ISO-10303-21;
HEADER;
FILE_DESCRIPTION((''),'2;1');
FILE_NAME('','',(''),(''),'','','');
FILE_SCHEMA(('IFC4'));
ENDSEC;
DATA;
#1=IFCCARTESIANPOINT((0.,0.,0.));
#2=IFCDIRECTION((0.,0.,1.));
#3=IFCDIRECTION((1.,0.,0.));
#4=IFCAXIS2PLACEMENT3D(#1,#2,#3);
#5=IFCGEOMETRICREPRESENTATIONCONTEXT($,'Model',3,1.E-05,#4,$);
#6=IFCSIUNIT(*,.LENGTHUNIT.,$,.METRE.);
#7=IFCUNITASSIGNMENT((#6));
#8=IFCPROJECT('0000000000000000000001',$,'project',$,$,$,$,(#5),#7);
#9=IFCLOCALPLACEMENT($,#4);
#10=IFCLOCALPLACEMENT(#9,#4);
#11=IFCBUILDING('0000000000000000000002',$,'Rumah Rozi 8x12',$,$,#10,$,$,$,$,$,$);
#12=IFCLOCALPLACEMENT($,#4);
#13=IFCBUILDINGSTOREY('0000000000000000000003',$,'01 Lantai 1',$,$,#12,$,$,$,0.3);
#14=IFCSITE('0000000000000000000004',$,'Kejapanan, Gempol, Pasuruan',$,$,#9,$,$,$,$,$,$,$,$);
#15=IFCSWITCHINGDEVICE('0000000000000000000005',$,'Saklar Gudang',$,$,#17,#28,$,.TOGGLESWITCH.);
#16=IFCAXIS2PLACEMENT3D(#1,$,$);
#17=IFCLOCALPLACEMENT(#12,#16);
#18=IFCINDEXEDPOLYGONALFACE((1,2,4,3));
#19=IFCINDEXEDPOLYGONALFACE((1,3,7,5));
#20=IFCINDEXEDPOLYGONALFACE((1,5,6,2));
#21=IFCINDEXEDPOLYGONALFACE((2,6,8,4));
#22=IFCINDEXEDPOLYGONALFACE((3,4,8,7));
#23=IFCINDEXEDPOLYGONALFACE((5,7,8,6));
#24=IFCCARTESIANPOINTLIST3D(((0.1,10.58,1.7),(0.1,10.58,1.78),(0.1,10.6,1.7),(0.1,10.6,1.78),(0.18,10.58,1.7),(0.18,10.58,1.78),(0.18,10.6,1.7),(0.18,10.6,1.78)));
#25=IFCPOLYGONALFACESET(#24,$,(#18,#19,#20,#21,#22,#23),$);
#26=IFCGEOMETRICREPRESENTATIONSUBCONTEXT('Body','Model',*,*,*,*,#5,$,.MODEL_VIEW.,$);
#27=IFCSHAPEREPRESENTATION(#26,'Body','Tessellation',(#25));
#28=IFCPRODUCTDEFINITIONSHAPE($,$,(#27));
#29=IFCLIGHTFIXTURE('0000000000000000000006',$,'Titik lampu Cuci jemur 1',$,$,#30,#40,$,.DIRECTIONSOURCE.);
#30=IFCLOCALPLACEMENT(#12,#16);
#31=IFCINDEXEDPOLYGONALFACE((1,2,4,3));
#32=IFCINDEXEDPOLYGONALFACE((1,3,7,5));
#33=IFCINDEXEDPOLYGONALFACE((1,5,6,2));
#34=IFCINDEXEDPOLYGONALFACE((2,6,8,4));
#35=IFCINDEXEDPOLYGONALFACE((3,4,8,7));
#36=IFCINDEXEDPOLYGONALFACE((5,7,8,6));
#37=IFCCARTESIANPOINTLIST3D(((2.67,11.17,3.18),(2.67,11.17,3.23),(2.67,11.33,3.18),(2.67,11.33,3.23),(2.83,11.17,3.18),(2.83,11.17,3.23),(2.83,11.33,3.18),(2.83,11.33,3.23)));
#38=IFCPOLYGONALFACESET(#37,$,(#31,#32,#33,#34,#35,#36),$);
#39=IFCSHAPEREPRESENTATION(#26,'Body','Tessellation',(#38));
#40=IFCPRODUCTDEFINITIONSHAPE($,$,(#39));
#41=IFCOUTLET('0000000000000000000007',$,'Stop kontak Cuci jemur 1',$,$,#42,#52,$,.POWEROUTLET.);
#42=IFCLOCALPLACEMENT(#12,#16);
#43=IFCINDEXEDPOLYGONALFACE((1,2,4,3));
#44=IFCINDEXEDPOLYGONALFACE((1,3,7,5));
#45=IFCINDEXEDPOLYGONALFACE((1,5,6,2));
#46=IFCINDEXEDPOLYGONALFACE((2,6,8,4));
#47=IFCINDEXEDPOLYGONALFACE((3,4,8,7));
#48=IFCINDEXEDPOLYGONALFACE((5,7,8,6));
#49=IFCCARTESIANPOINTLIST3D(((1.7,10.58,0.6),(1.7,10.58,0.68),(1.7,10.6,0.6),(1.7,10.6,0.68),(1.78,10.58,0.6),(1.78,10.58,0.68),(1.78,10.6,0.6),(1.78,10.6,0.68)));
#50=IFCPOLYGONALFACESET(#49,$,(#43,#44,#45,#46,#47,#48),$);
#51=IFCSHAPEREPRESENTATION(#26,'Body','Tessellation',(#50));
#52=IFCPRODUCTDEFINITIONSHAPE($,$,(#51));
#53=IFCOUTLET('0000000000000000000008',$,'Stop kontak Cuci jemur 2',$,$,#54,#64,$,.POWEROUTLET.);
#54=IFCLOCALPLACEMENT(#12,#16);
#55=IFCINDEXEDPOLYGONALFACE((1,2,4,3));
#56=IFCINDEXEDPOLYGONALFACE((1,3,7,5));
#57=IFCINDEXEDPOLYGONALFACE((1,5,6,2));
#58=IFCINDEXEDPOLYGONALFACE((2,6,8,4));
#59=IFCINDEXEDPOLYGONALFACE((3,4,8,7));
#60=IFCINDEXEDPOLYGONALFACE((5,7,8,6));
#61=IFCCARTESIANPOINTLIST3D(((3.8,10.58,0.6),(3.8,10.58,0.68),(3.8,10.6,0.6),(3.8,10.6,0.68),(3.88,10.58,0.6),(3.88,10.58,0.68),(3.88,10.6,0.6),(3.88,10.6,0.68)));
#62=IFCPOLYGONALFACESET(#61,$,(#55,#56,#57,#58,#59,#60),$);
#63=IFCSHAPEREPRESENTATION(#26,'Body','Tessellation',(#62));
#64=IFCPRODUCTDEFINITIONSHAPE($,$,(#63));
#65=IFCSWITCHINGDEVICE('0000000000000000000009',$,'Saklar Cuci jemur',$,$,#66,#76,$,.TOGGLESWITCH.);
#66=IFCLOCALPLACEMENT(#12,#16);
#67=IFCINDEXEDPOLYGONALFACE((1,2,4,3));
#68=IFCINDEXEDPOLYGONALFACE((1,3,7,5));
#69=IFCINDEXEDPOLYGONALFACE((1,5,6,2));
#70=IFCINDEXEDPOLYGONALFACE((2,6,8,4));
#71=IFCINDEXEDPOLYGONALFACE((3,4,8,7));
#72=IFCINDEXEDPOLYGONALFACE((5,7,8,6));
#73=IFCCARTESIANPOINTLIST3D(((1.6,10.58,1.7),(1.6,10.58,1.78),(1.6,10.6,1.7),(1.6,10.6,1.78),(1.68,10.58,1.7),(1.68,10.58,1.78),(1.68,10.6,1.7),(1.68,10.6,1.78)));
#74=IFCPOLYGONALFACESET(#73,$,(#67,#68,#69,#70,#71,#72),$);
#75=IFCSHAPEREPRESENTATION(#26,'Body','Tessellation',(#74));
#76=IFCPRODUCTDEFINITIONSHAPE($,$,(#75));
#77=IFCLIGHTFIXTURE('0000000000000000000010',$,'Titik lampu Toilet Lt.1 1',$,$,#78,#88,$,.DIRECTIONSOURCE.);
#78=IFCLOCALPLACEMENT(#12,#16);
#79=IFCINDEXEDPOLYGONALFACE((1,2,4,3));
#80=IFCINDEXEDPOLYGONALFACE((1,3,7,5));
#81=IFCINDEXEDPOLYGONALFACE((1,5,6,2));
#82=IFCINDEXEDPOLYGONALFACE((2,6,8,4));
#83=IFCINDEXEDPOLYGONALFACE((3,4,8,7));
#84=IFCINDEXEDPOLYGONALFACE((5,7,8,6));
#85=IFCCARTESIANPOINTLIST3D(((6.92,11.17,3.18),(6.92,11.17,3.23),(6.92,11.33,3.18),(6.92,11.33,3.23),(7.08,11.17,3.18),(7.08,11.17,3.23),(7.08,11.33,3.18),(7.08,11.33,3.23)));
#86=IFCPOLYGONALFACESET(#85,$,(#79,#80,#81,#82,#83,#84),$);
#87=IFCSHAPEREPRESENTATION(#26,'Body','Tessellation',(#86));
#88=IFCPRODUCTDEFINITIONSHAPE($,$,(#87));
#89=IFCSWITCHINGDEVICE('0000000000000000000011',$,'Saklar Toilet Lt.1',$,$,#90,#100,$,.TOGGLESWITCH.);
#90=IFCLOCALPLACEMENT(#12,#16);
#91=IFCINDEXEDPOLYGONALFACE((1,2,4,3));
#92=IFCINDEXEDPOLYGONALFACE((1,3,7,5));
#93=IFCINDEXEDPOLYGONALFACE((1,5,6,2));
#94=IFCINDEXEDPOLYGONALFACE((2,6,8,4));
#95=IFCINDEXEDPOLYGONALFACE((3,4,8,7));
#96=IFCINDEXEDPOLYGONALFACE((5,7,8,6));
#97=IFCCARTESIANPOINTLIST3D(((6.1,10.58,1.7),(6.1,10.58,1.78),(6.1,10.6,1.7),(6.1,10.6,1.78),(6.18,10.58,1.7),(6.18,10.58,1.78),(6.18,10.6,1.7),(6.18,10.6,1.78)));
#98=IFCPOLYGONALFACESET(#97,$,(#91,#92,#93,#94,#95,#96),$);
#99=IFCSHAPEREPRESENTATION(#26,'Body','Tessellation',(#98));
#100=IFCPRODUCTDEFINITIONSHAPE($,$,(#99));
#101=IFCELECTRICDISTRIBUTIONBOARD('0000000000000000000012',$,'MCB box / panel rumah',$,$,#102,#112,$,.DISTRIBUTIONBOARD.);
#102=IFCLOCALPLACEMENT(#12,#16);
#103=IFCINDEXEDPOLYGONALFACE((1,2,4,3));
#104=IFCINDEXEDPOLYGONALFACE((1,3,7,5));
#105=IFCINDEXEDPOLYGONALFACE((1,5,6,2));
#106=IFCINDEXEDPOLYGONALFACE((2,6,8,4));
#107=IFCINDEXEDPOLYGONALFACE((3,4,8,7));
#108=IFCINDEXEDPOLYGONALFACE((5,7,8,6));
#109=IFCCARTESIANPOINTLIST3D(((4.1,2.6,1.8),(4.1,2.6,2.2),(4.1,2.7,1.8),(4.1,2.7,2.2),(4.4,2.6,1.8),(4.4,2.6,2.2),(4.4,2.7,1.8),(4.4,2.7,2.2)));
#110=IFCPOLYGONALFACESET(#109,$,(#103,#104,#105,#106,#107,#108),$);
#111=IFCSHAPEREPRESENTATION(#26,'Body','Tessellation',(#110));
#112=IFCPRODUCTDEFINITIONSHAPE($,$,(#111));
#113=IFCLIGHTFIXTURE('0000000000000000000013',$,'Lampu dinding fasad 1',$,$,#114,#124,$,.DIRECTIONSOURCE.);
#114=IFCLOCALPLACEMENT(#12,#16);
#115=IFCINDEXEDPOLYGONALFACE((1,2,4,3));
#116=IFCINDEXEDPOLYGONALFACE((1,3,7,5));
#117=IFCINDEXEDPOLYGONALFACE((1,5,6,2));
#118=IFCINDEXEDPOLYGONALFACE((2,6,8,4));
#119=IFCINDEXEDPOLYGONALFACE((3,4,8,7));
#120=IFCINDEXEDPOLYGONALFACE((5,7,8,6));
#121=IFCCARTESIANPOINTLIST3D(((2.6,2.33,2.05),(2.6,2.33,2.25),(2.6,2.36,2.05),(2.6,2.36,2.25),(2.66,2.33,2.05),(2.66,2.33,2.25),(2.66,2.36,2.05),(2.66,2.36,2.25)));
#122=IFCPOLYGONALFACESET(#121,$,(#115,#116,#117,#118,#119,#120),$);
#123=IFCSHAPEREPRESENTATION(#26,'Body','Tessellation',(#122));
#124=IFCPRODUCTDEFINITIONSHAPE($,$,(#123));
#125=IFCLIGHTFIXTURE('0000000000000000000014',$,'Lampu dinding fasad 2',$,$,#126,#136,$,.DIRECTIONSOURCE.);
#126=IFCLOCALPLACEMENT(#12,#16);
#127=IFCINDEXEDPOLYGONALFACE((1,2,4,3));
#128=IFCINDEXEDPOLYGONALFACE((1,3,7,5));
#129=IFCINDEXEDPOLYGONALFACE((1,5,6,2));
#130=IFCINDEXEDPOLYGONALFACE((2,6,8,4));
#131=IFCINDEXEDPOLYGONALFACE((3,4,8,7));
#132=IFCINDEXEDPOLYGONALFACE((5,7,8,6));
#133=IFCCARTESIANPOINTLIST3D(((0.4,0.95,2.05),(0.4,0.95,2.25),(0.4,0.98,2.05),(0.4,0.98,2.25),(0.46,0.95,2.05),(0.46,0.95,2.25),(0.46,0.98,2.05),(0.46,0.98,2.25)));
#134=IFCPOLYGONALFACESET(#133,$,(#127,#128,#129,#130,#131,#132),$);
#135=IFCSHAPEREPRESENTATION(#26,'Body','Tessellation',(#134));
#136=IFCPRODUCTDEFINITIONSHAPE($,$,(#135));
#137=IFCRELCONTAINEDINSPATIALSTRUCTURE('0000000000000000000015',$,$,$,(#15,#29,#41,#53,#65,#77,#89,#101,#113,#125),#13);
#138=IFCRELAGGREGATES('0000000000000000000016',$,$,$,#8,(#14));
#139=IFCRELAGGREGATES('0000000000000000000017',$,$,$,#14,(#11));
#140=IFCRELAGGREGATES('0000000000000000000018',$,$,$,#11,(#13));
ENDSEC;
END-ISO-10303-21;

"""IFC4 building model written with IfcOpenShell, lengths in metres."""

from ifc_helpers import new_model, si_unit, frame, origin_with_axes, place, context, subcontext, project, spatial, line, indexed_curve, outline, extrude, element, save


model = new_model("IFC4")

# Units and contexts
model_context = context("Model", 3, precision=1e-05, world=origin_with_axes())
body_context = subcontext(model_context, "Body", "Model", "MODEL_VIEW")
ifc_project = project(units=[si_unit("LENGTHUNIT", "METRE")], contexts=[model_context])

# Site, building, storey
site_placement = place(None, origin_with_axes())
site = spatial("IfcSite", under=ifc_project, at=site_placement, Name="Kejapanan, Gempol, Pasuruan")
building_placement = place(site_placement, origin_with_axes())
building = spatial("IfcBuilding", under=site, at=building_placement, Name="Rumah Rozi 8x12")
storey_placement = place(None, origin_with_axes())
storey = spatial("IfcBuildingStorey", under=building, at=storey_placement, Name="01 Lantai 1", Elevation=0.3)

# Switching device
switching_device_1_placement = place(storey_placement, origin_with_axes())
element("IfcSwitchingDevice", 1, at=switching_device_1_placement, inside=storey, Name="Saklar Gudang", PredefinedType="TOGGLESWITCH", context=body_context, shape_type="SweptSolid", body=[
    extrude(outline(indexed_curve([(0.1, 10.58), (0.18, 10.58), (0.18, 10.6), (0.1, 10.6)], segments=[line(1, 2, 3, 4, 1)])), frame((0.0, 0.0, 1.7), z_axis=(0.0, 0.0, 1.0), x_axis=(1.0, 0.0, 0.0)), (0.0, 0.0, 1.0), 0.08),
])

# Light fixture
light_fixture_1_placement = place(storey_placement, origin_with_axes())
element("IfcLightFixture", 2, at=light_fixture_1_placement, inside=storey, Name="Titik lampu Cuci jemur 1", PredefinedType="DIRECTIONSOURCE", context=body_context, shape_type="SweptSolid", body=[
    extrude(outline(indexed_curve([(2.67, 11.17), (2.83, 11.17), (2.83, 11.33), (2.67, 11.33)], segments=[line(1, 2, 3, 4, 1)])), frame((0.0, 0.0, 3.18), z_axis=(0.0, 0.0, 1.0), x_axis=(1.0, 0.0, 0.0)), (0.0, 0.0, 1.0), 0.05),
])

# Outlets
outlet_1_placement = place(storey_placement, origin_with_axes())
element("IfcOutlet", 3, at=outlet_1_placement, inside=storey, Name="Stop kontak Cuci jemur 1", PredefinedType="POWEROUTLET", context=body_context, shape_type="SweptSolid", body=[
    extrude(outline(indexed_curve([(1.7, 10.58), (1.78, 10.58), (1.78, 10.6), (1.7, 10.6)], segments=[line(1, 2, 3, 4, 1)])), frame((0.0, 0.0, 0.6), z_axis=(0.0, 0.0, 1.0), x_axis=(1.0, 0.0, 0.0)), (0.0, 0.0, 1.0), 0.08),
])
outlet_2_placement = place(storey_placement, origin_with_axes())
element("IfcOutlet", 4, at=outlet_2_placement, inside=storey, Name="Stop kontak Cuci jemur 2", PredefinedType="POWEROUTLET", context=body_context, shape_type="SweptSolid", body=[
    extrude(outline(indexed_curve([(3.8, 10.58), (3.88, 10.58), (3.88, 10.6), (3.8, 10.6)], segments=[line(1, 2, 3, 4, 1)])), frame((0.0, 0.0, 0.6), z_axis=(0.0, 0.0, 1.0), x_axis=(1.0, 0.0, 0.0)), (0.0, 0.0, 1.0), 0.08),
])

# Switching device
switching_device_2_placement = place(storey_placement, origin_with_axes())
element("IfcSwitchingDevice", 5, at=switching_device_2_placement, inside=storey, Name="Saklar Cuci jemur", PredefinedType="TOGGLESWITCH", context=body_context, shape_type="SweptSolid", body=[
    extrude(outline(indexed_curve([(1.6, 10.58), (1.68, 10.58), (1.68, 10.6), (1.6, 10.6)], segments=[line(1, 2, 3, 4, 1)])), frame((0.0, 0.0, 1.7), z_axis=(0.0, 0.0, 1.0), x_axis=(1.0, 0.0, 0.0)), (0.0, 0.0, 1.0), 0.08),
])

# Light fixture
light_fixture_2_placement = place(storey_placement, origin_with_axes())
element("IfcLightFixture", 6, at=light_fixture_2_placement, inside=storey, Name="Titik lampu Toilet Lt.1 1", PredefinedType="DIRECTIONSOURCE", context=body_context, shape_type="SweptSolid", body=[
    extrude(outline(indexed_curve([(6.92, 11.17), (7.08, 11.17), (7.08, 11.33), (6.92, 11.33)], segments=[line(1, 2, 3, 4, 1)])), frame((0.0, 0.0, 3.18), z_axis=(0.0, 0.0, 1.0), x_axis=(1.0, 0.0, 0.0)), (0.0, 0.0, 1.0), 0.05),
])

# Switching device
switching_device_3_placement = place(storey_placement, origin_with_axes())
element("IfcSwitchingDevice", 7, at=switching_device_3_placement, inside=storey, Name="Saklar Toilet Lt.1", PredefinedType="TOGGLESWITCH", context=body_context, shape_type="SweptSolid", body=[
    extrude(outline(indexed_curve([(6.1, 10.58), (6.18, 10.58), (6.18, 10.6), (6.1, 10.6)], segments=[line(1, 2, 3, 4, 1)])), frame((0.0, 0.0, 1.7), z_axis=(0.0, 0.0, 1.0), x_axis=(1.0, 0.0, 0.0)), (0.0, 0.0, 1.0), 0.08),
])

# Electric distribution board
electric_distribution_board_placement = place(storey_placement, origin_with_axes())
element("IfcElectricDistributionBoard", 8, at=electric_distribution_board_placement, inside=storey, Name="MCB box / panel rumah", PredefinedType="DISTRIBUTIONBOARD", context=body_context, shape_type="SweptSolid", body=[
    extrude(outline(indexed_curve([(4.1, 2.6), (4.4, 2.6), (4.4, 2.7), (4.1, 2.7)], segments=[line(1, 2, 3, 4, 1)])), frame((0.0, 0.0, 1.8), z_axis=(0.0, 0.0, 1.0), x_axis=(1.0, 0.0, 0.0)), (0.0, 0.0, 1.0), 0.4),
])

# Light fixtures
light_fixture_3_placement = place(storey_placement, origin_with_axes())
element("IfcLightFixture", 9, at=light_fixture_3_placement, inside=storey, Name="Lampu dinding fasad 1", PredefinedType="DIRECTIONSOURCE", context=body_context, shape_type="SweptSolid", body=[
    extrude(outline(indexed_curve([(2.6, 2.33), (2.66, 2.33), (2.66, 2.36), (2.6, 2.36)], segments=[line(1, 2, 3, 4, 1)])), frame((0.0, 0.0, 2.05), z_axis=(0.0, 0.0, 1.0), x_axis=(1.0, 0.0, 0.0)), (0.0, 0.0, 1.0), 0.2),
])
light_fixture_4_placement = place(storey_placement, origin_with_axes())
element("IfcLightFixture", 10, at=light_fixture_4_placement, inside=storey, Name="Lampu dinding fasad 2", PredefinedType="DIRECTIONSOURCE", context=body_context, shape_type="SweptSolid", body=[
    extrude(outline(indexed_curve([(0.4, 0.95), (0.46, 0.95), (0.46, 0.98), (0.4, 0.98)], segments=[line(1, 2, 3, 4, 1)])), frame((0.0, 0.0, 2.05), z_axis=(0.0, 0.0, 1.0), x_axis=(1.0, 0.0, 0.0)), (0.0, 0.0, 1.0), 0.2),
])

save(model, "model.ifc")
